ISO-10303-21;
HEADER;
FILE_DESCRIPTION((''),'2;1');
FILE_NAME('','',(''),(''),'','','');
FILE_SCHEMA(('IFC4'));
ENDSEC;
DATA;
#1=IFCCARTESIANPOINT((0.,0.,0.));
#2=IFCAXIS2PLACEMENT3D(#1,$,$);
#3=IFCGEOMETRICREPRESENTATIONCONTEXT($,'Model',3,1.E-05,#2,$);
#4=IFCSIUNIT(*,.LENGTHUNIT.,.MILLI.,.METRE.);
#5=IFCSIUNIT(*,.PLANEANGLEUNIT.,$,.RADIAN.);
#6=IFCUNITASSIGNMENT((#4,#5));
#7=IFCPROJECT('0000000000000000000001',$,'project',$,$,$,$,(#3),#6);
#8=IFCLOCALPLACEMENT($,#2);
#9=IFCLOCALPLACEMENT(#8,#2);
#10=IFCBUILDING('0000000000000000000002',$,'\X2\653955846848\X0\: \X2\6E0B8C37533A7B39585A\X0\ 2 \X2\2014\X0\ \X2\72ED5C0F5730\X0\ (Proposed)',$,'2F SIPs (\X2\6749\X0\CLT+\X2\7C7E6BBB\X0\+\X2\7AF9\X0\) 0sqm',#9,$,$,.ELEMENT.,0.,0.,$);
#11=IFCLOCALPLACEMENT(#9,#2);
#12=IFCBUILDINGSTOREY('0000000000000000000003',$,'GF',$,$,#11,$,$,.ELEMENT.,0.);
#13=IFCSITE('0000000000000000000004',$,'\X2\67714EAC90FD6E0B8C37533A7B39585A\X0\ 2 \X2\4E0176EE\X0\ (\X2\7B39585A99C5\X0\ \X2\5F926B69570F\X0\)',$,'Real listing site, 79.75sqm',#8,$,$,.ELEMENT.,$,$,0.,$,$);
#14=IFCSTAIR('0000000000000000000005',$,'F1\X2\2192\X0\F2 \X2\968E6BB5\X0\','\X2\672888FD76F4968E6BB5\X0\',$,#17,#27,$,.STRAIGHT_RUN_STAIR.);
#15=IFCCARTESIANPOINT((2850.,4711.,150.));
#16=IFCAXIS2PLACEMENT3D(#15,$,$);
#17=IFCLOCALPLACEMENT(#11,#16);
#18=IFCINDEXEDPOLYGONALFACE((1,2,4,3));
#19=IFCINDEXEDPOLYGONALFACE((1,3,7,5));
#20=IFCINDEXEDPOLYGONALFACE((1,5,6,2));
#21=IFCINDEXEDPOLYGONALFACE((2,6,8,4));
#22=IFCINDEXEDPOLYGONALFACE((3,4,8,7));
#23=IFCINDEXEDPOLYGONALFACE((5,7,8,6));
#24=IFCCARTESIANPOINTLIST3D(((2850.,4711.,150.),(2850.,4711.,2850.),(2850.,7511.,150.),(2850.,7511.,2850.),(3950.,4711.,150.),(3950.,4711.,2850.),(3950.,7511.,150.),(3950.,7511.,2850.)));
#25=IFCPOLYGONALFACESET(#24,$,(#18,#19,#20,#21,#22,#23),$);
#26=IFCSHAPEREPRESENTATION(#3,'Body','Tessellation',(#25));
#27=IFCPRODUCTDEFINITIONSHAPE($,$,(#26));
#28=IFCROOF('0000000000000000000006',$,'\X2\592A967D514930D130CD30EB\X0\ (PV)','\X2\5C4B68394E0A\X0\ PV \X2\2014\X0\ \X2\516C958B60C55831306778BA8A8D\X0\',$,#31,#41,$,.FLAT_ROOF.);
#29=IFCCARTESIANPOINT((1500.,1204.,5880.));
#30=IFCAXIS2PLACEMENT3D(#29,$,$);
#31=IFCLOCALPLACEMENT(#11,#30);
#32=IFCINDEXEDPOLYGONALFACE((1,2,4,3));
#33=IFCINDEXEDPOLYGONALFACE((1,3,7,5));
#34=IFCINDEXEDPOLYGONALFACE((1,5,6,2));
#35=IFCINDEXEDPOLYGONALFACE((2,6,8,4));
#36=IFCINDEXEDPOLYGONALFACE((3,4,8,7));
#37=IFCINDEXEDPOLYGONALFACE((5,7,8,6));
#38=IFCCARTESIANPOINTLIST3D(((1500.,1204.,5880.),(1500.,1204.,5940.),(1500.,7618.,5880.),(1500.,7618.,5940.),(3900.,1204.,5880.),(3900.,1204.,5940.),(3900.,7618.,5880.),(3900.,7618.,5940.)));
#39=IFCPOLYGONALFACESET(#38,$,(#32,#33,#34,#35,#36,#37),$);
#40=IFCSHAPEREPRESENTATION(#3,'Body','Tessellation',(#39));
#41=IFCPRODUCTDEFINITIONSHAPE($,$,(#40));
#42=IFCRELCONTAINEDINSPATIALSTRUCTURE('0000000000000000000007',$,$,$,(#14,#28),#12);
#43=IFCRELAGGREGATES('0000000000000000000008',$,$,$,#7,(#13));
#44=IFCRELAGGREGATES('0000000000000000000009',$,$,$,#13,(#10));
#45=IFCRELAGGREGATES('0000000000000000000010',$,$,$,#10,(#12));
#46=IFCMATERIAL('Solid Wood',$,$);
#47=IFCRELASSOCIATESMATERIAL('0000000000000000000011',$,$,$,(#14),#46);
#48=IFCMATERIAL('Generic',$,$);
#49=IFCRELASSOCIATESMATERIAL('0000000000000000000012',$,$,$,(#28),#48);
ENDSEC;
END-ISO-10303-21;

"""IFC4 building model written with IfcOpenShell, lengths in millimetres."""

from ifc_helpers import new_model, si_unit, frame, frame_2d, origin, place, context, project, spatial, rectangle, extrude, material, element, save


model = new_model("IFC4")

# Units and contexts
model_context = context("Model", 3, precision=1e-05, world=origin())
ifc_project = project(units=[si_unit("LENGTHUNIT", "METRE", prefix="MILLI"), si_unit("PLANEANGLEUNIT", "RADIAN")], contexts=[model_context])

# Site, building, storey
site_placement = place(None, origin())
site = spatial("IfcSite", under=ifc_project, at=site_placement, Name="東京都渋谷区笹塚 2 丁目 (笹塚駅 徒歩圏)", ObjectType="Real listing site, 79.75sqm", CompositionType="ELEMENT", RefElevation=0.0)
building_placement = place(site_placement, origin())
building = spatial("IfcBuilding", under=site, at=building_placement, Name="改善案: 渋谷区笹塚 2 — 狭小地 (Proposed)", ObjectType="2F SIPs (杉CLT+籾殻+竹) 0sqm", CompositionType="ELEMENT", ElevationOfRefHeight=0.0, ElevationOfTerrain=0.0)
storey_placement = place(building_placement, origin())
storey = spatial("IfcBuildingStorey", under=building, at=storey_placement, Name="GF", CompositionType="ELEMENT", Elevation=0.0)

# Shared definitions
ifc_material_1 = material(Name="Generic")

# Stair
ifc_material_2 = material(Name="Solid Wood")
stair_placement = place(storey_placement, frame((2850.0, 4711.0, 150.0)))
element("IfcStair", 1, at=stair_placement, inside=storey, material=ifc_material_2, Name="F1→F2 階段", Description="木製直階段", PredefinedType="STRAIGHT_RUN_STAIR", context=model_context, shape_type="SweptSolid", body=[
    extrude(rectangle(XDim=1100.0, YDim=2800.0, at=frame_2d((550.0, 1400.0))), frame((2850.0, 4711.0, 150.0)), (0.0, 0.0, 1.0), 2700.0),
])

# Roof
roof_placement = place(storey_placement, frame((1500.0, 1204.0, 5880.0)))
element("IfcRoof", 2, at=roof_placement, inside=storey, material=ifc_material_1, Name="太陽光パネル (PV)", Description="屋根上 PV — 公開情報で確認", PredefinedType="FLAT_ROOF", context=model_context, shape_type="SweptSolid", body=[
    extrude(rectangle(XDim=2400.0, YDim=6414.0, at=frame_2d((1200.0, 3207.0))), frame((1500.0, 1204.0, 5880.0)), (0.0, 0.0, 1.0), 60.0),
])

save(model, "model.ifc")
